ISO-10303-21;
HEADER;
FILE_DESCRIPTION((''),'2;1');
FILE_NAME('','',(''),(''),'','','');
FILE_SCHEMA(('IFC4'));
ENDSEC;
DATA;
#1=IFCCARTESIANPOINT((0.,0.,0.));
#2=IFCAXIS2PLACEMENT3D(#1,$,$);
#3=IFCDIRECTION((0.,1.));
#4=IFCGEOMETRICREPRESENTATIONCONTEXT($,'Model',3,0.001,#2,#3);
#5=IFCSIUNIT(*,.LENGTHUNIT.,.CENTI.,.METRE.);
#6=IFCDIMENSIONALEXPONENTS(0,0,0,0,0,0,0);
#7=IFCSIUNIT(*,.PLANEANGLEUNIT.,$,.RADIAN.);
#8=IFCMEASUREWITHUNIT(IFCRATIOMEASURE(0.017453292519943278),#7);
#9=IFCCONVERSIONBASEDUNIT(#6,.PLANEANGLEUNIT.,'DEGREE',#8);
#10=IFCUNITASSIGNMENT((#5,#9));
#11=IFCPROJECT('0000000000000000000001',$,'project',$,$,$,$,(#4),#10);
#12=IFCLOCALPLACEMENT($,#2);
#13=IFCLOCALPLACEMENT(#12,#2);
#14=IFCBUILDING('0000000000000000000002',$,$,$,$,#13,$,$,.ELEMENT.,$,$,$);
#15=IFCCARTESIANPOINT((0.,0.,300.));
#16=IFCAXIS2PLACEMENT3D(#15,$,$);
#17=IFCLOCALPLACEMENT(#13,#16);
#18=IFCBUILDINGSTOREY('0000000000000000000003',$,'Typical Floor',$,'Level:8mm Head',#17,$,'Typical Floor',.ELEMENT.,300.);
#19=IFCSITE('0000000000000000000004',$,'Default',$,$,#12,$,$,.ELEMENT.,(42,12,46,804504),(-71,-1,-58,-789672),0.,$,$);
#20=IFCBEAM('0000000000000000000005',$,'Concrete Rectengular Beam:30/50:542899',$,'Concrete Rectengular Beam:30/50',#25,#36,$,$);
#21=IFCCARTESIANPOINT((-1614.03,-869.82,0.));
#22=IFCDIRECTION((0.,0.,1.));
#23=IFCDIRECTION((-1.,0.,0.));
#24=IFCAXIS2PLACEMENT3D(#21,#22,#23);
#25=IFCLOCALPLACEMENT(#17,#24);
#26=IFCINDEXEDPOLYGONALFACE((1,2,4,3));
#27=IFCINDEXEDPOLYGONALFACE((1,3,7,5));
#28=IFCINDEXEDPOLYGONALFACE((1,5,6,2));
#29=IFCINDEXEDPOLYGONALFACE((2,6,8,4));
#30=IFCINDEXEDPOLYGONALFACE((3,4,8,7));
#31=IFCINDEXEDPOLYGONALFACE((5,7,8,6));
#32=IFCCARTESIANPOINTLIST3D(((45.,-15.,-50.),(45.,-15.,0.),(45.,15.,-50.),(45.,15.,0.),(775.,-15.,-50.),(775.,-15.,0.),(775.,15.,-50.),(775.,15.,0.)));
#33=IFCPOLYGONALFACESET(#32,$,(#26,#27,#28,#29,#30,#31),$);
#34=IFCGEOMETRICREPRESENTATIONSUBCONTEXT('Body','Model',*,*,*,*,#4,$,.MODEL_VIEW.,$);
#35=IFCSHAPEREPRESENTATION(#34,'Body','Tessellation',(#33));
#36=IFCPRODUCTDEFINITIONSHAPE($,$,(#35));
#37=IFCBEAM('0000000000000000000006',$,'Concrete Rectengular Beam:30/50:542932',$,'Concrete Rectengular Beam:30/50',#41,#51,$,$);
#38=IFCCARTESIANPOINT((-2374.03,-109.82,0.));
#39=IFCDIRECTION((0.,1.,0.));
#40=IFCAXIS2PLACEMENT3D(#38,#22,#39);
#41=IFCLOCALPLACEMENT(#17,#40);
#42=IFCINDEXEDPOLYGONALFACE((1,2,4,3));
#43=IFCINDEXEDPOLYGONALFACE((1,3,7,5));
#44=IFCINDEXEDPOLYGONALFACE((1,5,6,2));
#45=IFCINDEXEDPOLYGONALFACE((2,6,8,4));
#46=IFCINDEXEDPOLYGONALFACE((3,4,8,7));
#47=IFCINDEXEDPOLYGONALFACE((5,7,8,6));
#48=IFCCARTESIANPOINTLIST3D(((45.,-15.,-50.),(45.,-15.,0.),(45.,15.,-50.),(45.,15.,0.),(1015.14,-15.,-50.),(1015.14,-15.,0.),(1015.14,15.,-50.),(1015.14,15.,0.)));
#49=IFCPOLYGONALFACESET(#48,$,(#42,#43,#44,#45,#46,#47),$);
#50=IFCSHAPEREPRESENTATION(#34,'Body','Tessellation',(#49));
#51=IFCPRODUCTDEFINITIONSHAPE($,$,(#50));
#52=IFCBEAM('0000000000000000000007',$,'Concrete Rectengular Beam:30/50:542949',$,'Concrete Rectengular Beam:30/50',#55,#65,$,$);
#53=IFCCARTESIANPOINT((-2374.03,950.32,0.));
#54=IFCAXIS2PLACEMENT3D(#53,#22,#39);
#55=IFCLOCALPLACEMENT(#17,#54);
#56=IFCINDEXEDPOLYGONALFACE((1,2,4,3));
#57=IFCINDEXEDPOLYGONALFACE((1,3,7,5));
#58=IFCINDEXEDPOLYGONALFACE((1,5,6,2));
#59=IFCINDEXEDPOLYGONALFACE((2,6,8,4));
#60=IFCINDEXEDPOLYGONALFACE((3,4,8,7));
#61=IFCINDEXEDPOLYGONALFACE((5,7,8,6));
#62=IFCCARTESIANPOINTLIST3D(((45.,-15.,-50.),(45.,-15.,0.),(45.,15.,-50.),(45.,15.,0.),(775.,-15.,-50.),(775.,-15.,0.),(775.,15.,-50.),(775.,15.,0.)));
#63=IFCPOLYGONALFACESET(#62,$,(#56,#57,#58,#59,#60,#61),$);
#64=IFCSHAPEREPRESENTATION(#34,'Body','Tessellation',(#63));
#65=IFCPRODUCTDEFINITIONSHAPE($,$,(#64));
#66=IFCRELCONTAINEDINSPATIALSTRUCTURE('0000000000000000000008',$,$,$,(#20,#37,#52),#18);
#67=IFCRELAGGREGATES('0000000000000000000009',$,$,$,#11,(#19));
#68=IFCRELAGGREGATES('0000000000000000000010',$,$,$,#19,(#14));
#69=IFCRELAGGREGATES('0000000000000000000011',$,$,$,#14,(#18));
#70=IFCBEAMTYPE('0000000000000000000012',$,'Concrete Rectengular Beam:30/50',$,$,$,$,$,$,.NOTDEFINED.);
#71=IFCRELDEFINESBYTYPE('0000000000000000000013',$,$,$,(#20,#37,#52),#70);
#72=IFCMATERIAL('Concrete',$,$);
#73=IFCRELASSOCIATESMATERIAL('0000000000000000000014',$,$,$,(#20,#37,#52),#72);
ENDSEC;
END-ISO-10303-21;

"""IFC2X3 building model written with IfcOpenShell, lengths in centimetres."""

from ifc_helpers import new_model, entity, si_unit, converted_unit, direction, frame, frame_2d, origin, place, context, subcontext, project, spatial, rectangle, extrude, material, type_object, element, save


model = new_model("IFC2X3")

# Units and contexts
model_context = context("Model", 3, precision=0.001, world=origin(), true_north=direction((0.0, 1.0)))
body_context = subcontext(model_context, "Body", "Model", "MODEL_VIEW")
ifc_project = project(units=[si_unit("LENGTHUNIT", "METRE", prefix="CENTI"), converted_unit("PLANEANGLEUNIT", "DEGREE", entity("IfcRatioMeasure", 0.017453292519943278), si_unit("PLANEANGLEUNIT", "RADIAN"), dimensions=[0, 0, 0, 0, 0, 0, 0])], contexts=[model_context])

# Site, building, storey
site_placement = place(None, origin())
site = spatial("IfcSite", under=ifc_project, at=site_placement, Name="Default", CompositionType="ELEMENT", RefLatitude=(42, 12, 46, 804504), RefLongitude=(-71, -1, -58, -789672), RefElevation=0.0)
building_placement = place(site_placement, origin())
building = spatial("IfcBuilding", under=site, at=building_placement, CompositionType="ELEMENT")
storey_placement = place(building_placement, frame((0.0, 0.0, 300.0)))
storey = spatial("IfcBuildingStorey", under=building, at=storey_placement, Name="Typical Floor", ObjectType="Level:8mm Head", LongName="Typical Floor", CompositionType="ELEMENT", Elevation=300.0)

# Beams
ifc_material = material(Name="Concrete")
beam_type_1 = type_object("IfcBeamType", Name="Concrete Rectengular Beam:30/50", PredefinedType="NOTDEFINED")
beam_1_placement = place(storey_placement, frame((-1614.03, -869.82, 0.0), z_axis=(0.0, 0.0, 1.0), x_axis=(-1.0, 0.0, 0.0)))
element("IfcBeam", 1, at=beam_1_placement, inside=storey, type_object=beam_type_1, material=ifc_material, Name="Concrete Rectengular Beam:30/50:542899", ObjectType="Concrete Rectengular Beam:30/50", context=body_context, shape_type="SweptSolid", body=[
    extrude(rectangle(XDim=50.0, YDim=30.0, at=frame_2d((0.0, 0.0), x_axis=(1.0, 0.0))), frame((45.0, 0.0, -25.0), z_axis=(1.0, 0.0, 0.0), x_axis=(0.0, 0.0, -1.0)), (0.0, 0.0, 1.0), 730.0),
])
beam_2_placement = place(storey_placement, frame((-2374.03, -109.82, 0.0), z_axis=(0.0, 0.0, 1.0), x_axis=(0.0, 1.0, 0.0)))
element("IfcBeam", 2, at=beam_2_placement, inside=storey, type_object=beam_type_1, material=ifc_material, Name="Concrete Rectengular Beam:30/50:542932", ObjectType="Concrete Rectengular Beam:30/50", context=body_context, shape_type="SweptSolid", body=[
    extrude(rectangle(XDim=50.0, YDim=30.0, at=frame_2d((0.0, 0.0), x_axis=(1.0, 0.0))), frame((45.0, 0.0, -25.0), z_axis=(1.0, 0.0, 0.0), x_axis=(0.0, 0.0, -1.0)), (0.0, 0.0, 1.0), 970.14),
])
beam_3_placement = place(storey_placement, frame((-2374.03, 950.32, 0.0), z_axis=(0.0, 0.0, 1.0), x_axis=(0.0, 1.0, 0.0)))
element("IfcBeam", 3, at=beam_3_placement, inside=storey, type_object=beam_type_1, material=ifc_material, Name="Concrete Rectengular Beam:30/50:542949", ObjectType="Concrete Rectengular Beam:30/50", context=body_context, shape_type="SweptSolid", body=[
    extrude(rectangle(XDim=50.0, YDim=30.0, at=frame_2d((0.0, 0.0), x_axis=(1.0, 0.0))), frame((45.0, 0.0, -25.0), z_axis=(1.0, 0.0, 0.0), x_axis=(0.0, 0.0, -1.0)), (0.0, 0.0, 1.0), 730.0),
])

save(model, "model.ifc")
